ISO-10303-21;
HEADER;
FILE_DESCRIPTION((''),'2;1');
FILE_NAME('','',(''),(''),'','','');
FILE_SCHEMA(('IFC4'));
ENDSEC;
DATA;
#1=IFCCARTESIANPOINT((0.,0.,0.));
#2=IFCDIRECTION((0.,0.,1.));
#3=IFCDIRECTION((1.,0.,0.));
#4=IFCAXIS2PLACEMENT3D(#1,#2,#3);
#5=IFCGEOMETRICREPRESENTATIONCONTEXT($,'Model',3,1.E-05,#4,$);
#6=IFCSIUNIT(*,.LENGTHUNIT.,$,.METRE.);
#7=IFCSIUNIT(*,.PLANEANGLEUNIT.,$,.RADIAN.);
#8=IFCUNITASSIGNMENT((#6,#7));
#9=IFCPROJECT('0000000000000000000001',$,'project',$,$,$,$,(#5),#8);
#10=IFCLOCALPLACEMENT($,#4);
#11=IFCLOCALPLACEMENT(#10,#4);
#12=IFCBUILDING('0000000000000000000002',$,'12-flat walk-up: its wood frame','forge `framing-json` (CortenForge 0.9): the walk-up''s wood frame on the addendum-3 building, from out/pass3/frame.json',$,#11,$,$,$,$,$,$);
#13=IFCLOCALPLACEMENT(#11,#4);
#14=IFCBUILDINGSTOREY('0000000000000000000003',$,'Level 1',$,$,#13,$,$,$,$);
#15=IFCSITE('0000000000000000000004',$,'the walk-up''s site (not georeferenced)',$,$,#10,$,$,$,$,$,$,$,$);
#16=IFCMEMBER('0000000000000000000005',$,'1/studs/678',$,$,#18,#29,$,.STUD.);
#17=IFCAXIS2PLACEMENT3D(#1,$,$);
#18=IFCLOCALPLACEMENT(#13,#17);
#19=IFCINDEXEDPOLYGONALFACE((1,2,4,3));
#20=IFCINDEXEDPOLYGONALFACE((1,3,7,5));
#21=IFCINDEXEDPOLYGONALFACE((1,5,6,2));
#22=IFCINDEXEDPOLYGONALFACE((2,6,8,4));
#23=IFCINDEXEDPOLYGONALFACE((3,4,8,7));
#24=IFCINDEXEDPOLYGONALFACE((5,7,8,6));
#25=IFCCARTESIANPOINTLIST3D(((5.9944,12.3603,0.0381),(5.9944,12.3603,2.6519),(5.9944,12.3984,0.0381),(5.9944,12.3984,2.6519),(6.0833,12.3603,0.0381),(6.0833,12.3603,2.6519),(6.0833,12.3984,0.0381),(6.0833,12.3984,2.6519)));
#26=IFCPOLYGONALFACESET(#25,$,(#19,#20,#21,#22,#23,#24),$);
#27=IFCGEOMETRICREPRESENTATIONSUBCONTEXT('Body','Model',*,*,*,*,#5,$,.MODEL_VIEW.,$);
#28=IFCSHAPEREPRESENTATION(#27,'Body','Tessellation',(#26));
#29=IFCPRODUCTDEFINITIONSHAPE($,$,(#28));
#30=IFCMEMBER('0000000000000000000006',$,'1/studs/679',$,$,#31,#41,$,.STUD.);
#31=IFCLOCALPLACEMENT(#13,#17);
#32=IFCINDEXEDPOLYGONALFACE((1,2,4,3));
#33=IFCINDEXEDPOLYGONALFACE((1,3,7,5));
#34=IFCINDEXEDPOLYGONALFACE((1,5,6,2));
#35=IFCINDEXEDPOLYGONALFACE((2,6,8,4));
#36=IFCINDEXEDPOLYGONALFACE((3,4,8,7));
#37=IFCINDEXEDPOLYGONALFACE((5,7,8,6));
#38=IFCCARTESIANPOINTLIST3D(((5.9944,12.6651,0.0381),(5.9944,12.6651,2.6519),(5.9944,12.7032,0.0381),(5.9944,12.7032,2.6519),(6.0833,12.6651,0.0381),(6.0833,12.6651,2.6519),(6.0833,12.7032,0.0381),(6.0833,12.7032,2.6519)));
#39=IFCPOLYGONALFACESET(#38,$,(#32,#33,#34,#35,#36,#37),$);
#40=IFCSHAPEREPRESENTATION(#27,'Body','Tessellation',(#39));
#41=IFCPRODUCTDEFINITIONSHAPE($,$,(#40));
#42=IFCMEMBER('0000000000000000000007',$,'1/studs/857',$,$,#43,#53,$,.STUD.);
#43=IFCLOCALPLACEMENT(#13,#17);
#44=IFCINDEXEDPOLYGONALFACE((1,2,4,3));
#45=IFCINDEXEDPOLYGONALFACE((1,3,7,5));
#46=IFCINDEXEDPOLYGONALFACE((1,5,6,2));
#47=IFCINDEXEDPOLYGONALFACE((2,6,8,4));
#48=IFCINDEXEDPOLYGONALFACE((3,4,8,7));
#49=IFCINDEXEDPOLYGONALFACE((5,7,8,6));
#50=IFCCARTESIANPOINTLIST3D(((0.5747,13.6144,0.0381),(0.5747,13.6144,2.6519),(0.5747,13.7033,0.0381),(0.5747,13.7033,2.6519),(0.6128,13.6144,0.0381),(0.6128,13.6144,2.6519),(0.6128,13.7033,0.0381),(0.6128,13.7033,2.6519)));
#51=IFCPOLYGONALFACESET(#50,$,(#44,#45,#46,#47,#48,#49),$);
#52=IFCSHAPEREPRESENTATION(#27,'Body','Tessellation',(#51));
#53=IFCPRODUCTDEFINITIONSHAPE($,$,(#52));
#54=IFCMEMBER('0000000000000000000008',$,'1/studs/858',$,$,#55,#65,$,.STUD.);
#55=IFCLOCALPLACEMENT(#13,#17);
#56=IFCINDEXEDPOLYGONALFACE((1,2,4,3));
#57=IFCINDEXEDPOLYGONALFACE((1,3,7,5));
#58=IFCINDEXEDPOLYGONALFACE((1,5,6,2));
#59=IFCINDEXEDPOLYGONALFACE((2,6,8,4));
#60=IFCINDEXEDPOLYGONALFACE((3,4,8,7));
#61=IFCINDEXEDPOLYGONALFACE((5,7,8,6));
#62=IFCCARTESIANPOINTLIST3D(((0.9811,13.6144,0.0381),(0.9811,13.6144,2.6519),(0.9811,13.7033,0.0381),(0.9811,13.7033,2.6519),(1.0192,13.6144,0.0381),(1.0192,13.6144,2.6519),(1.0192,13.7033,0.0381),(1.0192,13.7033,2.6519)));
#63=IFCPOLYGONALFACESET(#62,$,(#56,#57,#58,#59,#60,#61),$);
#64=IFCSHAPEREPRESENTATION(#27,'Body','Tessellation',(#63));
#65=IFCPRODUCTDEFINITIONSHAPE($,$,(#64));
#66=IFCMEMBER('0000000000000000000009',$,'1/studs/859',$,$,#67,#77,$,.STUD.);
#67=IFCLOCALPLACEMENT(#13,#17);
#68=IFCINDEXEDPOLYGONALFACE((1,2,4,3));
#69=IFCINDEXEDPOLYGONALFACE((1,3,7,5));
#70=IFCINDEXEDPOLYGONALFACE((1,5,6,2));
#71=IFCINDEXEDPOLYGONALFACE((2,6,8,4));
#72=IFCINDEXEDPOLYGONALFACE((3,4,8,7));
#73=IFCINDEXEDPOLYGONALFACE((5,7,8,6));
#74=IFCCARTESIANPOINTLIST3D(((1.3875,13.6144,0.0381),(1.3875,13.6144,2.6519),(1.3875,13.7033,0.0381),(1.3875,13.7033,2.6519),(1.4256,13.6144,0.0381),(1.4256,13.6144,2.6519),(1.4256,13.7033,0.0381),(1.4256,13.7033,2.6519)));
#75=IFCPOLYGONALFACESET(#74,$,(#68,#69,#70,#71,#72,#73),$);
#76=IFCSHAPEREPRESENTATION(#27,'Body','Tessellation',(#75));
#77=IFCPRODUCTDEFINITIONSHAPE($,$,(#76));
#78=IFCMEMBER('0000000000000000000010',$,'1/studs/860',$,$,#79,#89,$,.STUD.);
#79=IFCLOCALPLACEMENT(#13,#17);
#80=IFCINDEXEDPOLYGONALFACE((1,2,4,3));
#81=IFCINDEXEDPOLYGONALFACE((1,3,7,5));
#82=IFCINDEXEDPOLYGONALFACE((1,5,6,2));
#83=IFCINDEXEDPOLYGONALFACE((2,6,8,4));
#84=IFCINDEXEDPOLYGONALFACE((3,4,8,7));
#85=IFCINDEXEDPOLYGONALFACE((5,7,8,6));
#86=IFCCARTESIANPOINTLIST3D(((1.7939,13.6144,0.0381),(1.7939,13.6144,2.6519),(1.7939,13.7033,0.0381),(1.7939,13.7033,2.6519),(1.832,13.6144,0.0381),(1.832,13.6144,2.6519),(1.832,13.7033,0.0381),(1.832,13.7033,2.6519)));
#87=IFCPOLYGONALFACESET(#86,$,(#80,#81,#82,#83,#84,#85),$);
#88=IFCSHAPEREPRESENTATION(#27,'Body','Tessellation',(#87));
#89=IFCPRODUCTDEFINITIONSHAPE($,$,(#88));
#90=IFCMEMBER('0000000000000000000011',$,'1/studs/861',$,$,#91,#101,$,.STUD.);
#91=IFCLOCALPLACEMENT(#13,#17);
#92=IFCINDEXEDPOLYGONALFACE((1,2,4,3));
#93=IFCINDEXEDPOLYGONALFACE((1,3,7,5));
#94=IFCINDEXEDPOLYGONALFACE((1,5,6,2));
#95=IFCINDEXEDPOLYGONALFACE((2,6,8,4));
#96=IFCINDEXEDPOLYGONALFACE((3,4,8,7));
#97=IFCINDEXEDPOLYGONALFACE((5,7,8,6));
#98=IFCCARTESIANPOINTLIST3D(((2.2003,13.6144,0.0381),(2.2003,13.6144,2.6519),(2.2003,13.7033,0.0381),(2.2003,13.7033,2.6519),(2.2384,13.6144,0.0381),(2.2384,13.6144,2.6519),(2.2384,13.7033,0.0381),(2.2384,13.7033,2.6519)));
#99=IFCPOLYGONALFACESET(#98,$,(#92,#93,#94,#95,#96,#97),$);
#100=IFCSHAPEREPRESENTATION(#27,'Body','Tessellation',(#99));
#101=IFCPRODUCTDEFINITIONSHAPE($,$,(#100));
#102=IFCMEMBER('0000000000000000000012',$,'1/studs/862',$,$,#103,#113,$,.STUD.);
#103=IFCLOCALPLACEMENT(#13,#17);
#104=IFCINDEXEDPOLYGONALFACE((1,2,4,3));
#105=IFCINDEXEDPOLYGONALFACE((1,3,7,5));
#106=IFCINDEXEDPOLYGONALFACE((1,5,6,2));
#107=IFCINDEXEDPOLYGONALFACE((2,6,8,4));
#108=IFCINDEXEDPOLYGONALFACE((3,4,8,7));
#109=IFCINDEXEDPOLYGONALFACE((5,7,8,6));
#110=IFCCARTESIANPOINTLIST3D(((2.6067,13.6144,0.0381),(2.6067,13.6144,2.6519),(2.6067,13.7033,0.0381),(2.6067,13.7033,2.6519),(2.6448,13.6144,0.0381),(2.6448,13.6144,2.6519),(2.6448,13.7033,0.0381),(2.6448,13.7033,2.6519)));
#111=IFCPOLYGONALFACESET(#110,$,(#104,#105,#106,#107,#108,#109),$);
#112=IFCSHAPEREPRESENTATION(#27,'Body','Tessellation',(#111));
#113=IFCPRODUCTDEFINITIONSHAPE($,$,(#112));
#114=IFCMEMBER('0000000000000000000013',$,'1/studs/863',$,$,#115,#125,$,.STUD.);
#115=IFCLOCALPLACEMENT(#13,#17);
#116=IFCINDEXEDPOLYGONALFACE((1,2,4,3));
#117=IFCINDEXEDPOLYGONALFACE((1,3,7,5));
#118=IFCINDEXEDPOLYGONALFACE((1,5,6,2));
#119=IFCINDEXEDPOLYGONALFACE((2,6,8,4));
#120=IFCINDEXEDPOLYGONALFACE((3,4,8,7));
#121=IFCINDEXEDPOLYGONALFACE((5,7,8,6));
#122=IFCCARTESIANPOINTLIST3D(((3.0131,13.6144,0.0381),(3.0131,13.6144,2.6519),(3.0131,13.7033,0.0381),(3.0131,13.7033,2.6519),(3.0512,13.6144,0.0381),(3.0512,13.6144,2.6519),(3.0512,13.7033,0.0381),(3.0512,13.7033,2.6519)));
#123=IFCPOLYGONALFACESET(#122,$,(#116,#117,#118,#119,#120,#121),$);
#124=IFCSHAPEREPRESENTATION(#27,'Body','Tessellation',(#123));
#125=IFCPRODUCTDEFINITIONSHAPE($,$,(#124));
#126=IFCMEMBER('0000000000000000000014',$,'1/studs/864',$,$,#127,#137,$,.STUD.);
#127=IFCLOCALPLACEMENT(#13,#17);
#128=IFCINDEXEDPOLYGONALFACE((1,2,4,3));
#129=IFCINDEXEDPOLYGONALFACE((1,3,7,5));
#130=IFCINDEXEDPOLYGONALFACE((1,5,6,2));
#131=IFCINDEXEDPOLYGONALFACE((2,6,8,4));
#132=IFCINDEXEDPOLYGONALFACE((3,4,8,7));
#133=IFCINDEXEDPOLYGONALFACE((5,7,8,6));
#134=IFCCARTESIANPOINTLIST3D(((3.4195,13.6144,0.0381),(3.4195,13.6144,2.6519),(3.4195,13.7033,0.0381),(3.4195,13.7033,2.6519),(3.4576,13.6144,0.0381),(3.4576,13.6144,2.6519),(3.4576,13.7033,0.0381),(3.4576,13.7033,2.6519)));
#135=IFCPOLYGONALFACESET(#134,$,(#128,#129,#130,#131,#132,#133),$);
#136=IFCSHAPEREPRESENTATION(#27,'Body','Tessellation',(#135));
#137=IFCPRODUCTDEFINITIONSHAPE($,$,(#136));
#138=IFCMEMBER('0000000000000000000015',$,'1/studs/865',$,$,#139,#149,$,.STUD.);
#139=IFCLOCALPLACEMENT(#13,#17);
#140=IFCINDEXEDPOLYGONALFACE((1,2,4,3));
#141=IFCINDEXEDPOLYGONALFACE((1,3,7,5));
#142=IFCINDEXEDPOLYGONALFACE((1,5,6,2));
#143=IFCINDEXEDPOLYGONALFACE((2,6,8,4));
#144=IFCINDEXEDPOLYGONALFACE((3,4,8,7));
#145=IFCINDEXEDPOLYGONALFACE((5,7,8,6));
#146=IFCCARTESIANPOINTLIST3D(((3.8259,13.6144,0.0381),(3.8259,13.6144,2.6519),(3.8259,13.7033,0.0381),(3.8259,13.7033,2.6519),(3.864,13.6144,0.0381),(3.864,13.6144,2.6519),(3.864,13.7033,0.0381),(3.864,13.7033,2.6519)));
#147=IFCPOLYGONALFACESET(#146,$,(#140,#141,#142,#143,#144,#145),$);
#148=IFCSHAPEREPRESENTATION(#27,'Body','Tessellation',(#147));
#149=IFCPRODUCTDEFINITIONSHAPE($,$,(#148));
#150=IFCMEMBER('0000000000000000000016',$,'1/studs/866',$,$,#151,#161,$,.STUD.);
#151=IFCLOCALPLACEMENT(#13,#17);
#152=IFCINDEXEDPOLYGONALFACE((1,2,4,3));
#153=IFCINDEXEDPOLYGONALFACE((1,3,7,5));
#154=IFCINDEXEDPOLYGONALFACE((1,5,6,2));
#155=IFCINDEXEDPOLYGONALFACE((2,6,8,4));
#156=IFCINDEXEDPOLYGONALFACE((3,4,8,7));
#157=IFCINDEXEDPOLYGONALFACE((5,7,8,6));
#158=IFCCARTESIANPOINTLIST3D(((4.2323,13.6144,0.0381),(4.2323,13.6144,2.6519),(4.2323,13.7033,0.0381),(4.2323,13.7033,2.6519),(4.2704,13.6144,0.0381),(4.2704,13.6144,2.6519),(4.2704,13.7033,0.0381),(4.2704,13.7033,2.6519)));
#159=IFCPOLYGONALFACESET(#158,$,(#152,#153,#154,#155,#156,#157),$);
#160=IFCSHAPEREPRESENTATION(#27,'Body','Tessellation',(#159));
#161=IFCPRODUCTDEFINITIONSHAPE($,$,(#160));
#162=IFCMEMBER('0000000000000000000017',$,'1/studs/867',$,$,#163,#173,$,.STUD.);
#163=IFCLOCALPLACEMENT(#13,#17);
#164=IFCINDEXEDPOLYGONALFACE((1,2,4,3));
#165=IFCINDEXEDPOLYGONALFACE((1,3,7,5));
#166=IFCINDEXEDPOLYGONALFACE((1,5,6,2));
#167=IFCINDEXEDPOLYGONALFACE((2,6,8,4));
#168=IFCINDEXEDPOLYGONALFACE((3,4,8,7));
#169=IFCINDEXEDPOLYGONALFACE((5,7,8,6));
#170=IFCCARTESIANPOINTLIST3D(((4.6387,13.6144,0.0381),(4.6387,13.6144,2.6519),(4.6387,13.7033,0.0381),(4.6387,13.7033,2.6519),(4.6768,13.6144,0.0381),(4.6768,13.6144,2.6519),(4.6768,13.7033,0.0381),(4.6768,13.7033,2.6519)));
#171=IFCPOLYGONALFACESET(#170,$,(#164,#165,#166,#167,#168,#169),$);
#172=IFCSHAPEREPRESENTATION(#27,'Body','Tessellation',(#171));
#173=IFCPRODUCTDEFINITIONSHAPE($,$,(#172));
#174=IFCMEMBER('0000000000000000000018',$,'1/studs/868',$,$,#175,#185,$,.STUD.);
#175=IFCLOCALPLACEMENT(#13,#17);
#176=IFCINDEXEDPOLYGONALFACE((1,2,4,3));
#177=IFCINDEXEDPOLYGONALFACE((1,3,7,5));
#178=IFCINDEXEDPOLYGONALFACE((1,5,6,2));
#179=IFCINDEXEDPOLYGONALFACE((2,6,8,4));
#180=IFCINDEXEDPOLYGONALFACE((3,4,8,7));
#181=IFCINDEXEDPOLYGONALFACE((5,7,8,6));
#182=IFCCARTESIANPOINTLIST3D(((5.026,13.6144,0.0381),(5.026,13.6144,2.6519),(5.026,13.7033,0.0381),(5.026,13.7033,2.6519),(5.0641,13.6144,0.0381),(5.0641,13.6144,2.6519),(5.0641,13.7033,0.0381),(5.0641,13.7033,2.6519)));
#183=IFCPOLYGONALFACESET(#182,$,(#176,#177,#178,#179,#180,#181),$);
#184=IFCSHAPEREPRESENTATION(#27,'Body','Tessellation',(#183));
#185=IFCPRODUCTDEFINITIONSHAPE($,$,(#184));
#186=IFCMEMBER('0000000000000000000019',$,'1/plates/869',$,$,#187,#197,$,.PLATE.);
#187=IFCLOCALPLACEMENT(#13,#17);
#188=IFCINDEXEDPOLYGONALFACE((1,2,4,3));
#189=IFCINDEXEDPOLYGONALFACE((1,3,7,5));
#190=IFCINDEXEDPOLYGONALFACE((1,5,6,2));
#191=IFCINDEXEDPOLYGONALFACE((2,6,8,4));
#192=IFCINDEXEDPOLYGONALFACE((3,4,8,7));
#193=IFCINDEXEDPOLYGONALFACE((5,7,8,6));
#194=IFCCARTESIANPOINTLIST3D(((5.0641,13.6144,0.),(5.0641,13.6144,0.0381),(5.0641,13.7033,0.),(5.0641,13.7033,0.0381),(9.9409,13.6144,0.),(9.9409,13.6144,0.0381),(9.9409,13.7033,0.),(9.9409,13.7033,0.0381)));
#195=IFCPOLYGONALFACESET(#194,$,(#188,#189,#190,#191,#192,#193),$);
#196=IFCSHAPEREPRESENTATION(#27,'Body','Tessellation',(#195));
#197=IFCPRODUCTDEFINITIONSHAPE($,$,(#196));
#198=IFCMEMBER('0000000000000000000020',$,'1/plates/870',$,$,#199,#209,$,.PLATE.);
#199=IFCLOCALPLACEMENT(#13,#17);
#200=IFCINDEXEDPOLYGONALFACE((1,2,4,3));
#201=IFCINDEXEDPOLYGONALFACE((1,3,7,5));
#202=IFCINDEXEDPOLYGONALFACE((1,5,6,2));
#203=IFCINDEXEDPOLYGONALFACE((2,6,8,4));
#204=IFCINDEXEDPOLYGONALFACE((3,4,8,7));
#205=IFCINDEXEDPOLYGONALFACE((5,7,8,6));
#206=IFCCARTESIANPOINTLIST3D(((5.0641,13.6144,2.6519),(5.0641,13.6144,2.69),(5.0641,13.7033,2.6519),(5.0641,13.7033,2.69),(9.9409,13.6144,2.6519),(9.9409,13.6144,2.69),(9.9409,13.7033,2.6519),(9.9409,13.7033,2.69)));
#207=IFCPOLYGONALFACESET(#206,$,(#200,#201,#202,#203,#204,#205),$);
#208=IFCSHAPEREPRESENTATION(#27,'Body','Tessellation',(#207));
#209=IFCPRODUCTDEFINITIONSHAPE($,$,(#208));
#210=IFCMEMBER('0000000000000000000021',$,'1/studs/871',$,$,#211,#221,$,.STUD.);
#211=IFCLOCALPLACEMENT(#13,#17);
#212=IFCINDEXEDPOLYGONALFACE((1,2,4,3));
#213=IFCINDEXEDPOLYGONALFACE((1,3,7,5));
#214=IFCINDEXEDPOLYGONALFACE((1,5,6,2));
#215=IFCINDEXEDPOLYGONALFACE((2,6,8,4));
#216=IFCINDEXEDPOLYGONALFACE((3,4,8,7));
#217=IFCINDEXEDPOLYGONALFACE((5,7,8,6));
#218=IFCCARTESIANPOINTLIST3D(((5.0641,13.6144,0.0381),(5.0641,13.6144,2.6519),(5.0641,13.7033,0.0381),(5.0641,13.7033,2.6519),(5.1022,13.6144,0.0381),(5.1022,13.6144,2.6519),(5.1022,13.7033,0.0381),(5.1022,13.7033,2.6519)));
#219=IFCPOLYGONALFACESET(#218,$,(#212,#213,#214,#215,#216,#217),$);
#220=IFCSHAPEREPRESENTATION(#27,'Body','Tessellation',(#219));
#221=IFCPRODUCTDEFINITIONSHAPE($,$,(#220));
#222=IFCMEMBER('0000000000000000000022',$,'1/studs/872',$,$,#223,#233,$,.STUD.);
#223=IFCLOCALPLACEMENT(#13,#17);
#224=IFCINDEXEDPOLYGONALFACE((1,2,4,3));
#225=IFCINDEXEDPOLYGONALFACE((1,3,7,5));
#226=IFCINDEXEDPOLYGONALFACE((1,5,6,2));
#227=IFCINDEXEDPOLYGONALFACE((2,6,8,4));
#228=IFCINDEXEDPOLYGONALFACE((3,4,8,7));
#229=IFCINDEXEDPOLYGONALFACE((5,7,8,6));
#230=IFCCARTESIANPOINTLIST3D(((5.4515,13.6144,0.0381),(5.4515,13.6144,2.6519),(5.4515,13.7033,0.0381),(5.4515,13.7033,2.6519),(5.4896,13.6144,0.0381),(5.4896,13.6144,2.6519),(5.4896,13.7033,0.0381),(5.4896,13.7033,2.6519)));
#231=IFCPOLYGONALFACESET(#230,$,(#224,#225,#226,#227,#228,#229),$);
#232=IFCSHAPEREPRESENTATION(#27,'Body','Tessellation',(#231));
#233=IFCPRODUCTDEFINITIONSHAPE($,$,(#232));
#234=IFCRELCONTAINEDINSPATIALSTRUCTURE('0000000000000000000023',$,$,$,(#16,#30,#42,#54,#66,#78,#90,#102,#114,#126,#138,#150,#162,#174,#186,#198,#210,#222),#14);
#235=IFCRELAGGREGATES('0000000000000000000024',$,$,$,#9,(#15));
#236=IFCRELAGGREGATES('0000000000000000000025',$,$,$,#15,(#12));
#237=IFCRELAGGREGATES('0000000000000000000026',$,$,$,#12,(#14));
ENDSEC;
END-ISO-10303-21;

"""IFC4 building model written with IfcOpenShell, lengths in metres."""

from ifc_helpers import new_model, si_unit, frame, frame_2d, origin, origin_with_axes, place, context, subcontext, project, spatial, rectangle, extrude, element, save


model = new_model("IFC4")

# Units and contexts
model_context = context("Model", 3, precision=1e-05, world=origin_with_axes())
body_context = subcontext(model_context, "Body", "Model", "MODEL_VIEW")
ifc_project = project(units=[si_unit("LENGTHUNIT", "METRE"), si_unit("PLANEANGLEUNIT", "RADIAN")], contexts=[model_context])

# Site, building, storey
site_placement = place(None, origin_with_axes())
site = spatial("IfcSite", under=ifc_project, at=site_placement, Name="the walk-up's site (not georeferenced)")
building_placement = place(site_placement, origin_with_axes())
building = spatial("IfcBuilding", under=site, at=building_placement, Name="12-flat walk-up: its wood frame", Description="forge `framing-json` (CortenForge 0.9): the walk-up's wood frame on the addendum-3 building, from out/pass3/frame.json")
storey_placement = place(building_placement, origin_with_axes())
storey = spatial("IfcBuildingStorey", under=building, at=storey_placement, Name="Level 1")

# Members
for number, where, z_axis, x_axis, name in (
    (1, (5.9944, 12.3603, 0.0381), (0.0, 0.0, 1.0), (1.0, 0.0, 0.0), "1/studs/678"),
    (2, (5.9944, 12.6651, 0.0381), (0.0, 0.0, 1.0), (1.0, 0.0, 0.0), "1/studs/679"),
):
    element("IfcMember", number, at=place(storey_placement, frame(where, z_axis=z_axis, x_axis=x_axis)), inside=storey, Name=name, PredefinedType="STUD", context=body_context, shape_type="SweptSolid", body=[
        extrude(rectangle(XDim=0.0889, YDim=0.0381, at=frame_2d((0.0445, 0.0191))), origin(), (0.0, 0.0, 1.0), 2.6138),
    ])
for number, where, z_axis, x_axis, name in (
    (3, (0.5747, 13.6144, 0.0381), (0.0, 0.0, 1.0), (1.0, 0.0, 0.0), "1/studs/857"),
    (4, (0.9811, 13.6144, 0.0381), (0.0, 0.0, 1.0), (1.0, 0.0, 0.0), "1/studs/858"),
):
    element("IfcMember", number, at=place(storey_placement, frame(where, z_axis=z_axis, x_axis=x_axis)), inside=storey, Name=name, PredefinedType="STUD", context=body_context, shape_type="SweptSolid", body=[
        extrude(rectangle(XDim=0.0381, YDim=0.0889, at=frame_2d((0.019, 0.0445))), origin(), (0.0, 0.0, 1.0), 2.6138),
    ])
member_1_placement = place(storey_placement, frame((1.3875, 13.6144, 0.0381), z_axis=(0.0, 0.0, 1.0), x_axis=(1.0, 0.0, 0.0)))
element("IfcMember", 5, at=member_1_placement, inside=storey, Name="1/studs/859", PredefinedType="STUD", context=body_context, shape_type="SweptSolid", body=[
    extrude(rectangle(XDim=0.0381, YDim=0.0889, at=frame_2d((0.0191, 0.0445))), origin(), (0.0, 0.0, 1.0), 2.6138),
])
member_2_placement = place(storey_placement, frame((1.7939, 13.6144, 0.0381), z_axis=(0.0, 0.0, 1.0), x_axis=(1.0, 0.0, 0.0)))
element("IfcMember", 6, at=member_2_placement, inside=storey, Name="1/studs/860", PredefinedType="STUD", context=body_context, shape_type="SweptSolid", body=[
    extrude(rectangle(XDim=0.0381, YDim=0.0889, at=frame_2d((0.019, 0.0445))), origin(), (0.0, 0.0, 1.0), 2.6138),
])
for number, where, z_axis, x_axis, name in (
    (7, (2.2003, 13.6144, 0.0381), (0.0, 0.0, 1.0), (1.0, 0.0, 0.0), "1/studs/861"),
    (8, (2.6067, 13.6144, 0.0381), (0.0, 0.0, 1.0), (1.0, 0.0, 0.0), "1/studs/862"),
    (9, (3.0131, 13.6144, 0.0381), (0.0, 0.0, 1.0), (1.0, 0.0, 0.0), "1/studs/863"),
    (10, (3.4195, 13.6144, 0.0381), (0.0, 0.0, 1.0), (1.0, 0.0, 0.0), "1/studs/864"),
    (11, (3.8259, 13.6144, 0.0381), (0.0, 0.0, 1.0), (1.0, 0.0, 0.0), "1/studs/865"),
    (12, (4.2323, 13.6144, 0.0381), (0.0, 0.0, 1.0), (1.0, 0.0, 0.0), "1/studs/866"),
    (13, (4.6387, 13.6144, 0.0381), (0.0, 0.0, 1.0), (1.0, 0.0, 0.0), "1/studs/867"),
    (14, (5.026, 13.6144, 0.0381), (0.0, 0.0, 1.0), (1.0, 0.0, 0.0), "1/studs/868"),
):
    element("IfcMember", number, at=place(storey_placement, frame(where, z_axis=z_axis, x_axis=x_axis)), inside=storey, Name=name, PredefinedType="STUD", context=body_context, shape_type="SweptSolid", body=[
        extrude(rectangle(XDim=0.0381, YDim=0.0889, at=frame_2d((0.0191, 0.0445))), origin(), (0.0, 0.0, 1.0), 2.6138),
    ])
member_3_placement = place(storey_placement, frame((5.0641, 13.6144, 0.0), z_axis=(0.0, 0.0, 1.0), x_axis=(1.0, 0.0, 0.0)))
element("IfcMember", 15, at=member_3_placement, inside=storey, Name="1/plates/869", PredefinedType="PLATE", context=body_context, shape_type="SweptSolid", body=[
    extrude(rectangle(XDim=4.8768, YDim=0.0889, at=frame_2d((2.4384, 0.0445))), origin(), (0.0, 0.0, 1.0), 0.0381),
])
member_4_placement = place(storey_placement, frame((5.0641, 13.6144, 2.6519), z_axis=(0.0, 0.0, 1.0), x_axis=(1.0, 0.0, 0.0)))
element("IfcMember", 16, at=member_4_placement, inside=storey, Name="1/plates/870", PredefinedType="PLATE", context=body_context, shape_type="SweptSolid", body=[
    extrude(rectangle(XDim=4.8768, YDim=0.0889, at=frame_2d((2.4384, 0.0445))), origin(), (0.0, 0.0, 1.0), 0.0381),
])
for number, where, z_axis, x_axis, name in (
    (17, (5.0641, 13.6144, 0.0381), (0.0, 0.0, 1.0), (1.0, 0.0, 0.0), "1/studs/871"),
    (18, (5.4515, 13.6144, 0.0381), (0.0, 0.0, 1.0), (1.0, 0.0, 0.0), "1/studs/872"),
):
    element("IfcMember", number, at=place(storey_placement, frame(where, z_axis=z_axis, x_axis=x_axis)), inside=storey, Name=name, PredefinedType="STUD", context=body_context, shape_type="SweptSolid", body=[
        extrude(rectangle(XDim=0.0381, YDim=0.0889, at=frame_2d((0.0191, 0.0445))), origin(), (0.0, 0.0, 1.0), 2.6138),
    ])

save(model, "model.ifc")
